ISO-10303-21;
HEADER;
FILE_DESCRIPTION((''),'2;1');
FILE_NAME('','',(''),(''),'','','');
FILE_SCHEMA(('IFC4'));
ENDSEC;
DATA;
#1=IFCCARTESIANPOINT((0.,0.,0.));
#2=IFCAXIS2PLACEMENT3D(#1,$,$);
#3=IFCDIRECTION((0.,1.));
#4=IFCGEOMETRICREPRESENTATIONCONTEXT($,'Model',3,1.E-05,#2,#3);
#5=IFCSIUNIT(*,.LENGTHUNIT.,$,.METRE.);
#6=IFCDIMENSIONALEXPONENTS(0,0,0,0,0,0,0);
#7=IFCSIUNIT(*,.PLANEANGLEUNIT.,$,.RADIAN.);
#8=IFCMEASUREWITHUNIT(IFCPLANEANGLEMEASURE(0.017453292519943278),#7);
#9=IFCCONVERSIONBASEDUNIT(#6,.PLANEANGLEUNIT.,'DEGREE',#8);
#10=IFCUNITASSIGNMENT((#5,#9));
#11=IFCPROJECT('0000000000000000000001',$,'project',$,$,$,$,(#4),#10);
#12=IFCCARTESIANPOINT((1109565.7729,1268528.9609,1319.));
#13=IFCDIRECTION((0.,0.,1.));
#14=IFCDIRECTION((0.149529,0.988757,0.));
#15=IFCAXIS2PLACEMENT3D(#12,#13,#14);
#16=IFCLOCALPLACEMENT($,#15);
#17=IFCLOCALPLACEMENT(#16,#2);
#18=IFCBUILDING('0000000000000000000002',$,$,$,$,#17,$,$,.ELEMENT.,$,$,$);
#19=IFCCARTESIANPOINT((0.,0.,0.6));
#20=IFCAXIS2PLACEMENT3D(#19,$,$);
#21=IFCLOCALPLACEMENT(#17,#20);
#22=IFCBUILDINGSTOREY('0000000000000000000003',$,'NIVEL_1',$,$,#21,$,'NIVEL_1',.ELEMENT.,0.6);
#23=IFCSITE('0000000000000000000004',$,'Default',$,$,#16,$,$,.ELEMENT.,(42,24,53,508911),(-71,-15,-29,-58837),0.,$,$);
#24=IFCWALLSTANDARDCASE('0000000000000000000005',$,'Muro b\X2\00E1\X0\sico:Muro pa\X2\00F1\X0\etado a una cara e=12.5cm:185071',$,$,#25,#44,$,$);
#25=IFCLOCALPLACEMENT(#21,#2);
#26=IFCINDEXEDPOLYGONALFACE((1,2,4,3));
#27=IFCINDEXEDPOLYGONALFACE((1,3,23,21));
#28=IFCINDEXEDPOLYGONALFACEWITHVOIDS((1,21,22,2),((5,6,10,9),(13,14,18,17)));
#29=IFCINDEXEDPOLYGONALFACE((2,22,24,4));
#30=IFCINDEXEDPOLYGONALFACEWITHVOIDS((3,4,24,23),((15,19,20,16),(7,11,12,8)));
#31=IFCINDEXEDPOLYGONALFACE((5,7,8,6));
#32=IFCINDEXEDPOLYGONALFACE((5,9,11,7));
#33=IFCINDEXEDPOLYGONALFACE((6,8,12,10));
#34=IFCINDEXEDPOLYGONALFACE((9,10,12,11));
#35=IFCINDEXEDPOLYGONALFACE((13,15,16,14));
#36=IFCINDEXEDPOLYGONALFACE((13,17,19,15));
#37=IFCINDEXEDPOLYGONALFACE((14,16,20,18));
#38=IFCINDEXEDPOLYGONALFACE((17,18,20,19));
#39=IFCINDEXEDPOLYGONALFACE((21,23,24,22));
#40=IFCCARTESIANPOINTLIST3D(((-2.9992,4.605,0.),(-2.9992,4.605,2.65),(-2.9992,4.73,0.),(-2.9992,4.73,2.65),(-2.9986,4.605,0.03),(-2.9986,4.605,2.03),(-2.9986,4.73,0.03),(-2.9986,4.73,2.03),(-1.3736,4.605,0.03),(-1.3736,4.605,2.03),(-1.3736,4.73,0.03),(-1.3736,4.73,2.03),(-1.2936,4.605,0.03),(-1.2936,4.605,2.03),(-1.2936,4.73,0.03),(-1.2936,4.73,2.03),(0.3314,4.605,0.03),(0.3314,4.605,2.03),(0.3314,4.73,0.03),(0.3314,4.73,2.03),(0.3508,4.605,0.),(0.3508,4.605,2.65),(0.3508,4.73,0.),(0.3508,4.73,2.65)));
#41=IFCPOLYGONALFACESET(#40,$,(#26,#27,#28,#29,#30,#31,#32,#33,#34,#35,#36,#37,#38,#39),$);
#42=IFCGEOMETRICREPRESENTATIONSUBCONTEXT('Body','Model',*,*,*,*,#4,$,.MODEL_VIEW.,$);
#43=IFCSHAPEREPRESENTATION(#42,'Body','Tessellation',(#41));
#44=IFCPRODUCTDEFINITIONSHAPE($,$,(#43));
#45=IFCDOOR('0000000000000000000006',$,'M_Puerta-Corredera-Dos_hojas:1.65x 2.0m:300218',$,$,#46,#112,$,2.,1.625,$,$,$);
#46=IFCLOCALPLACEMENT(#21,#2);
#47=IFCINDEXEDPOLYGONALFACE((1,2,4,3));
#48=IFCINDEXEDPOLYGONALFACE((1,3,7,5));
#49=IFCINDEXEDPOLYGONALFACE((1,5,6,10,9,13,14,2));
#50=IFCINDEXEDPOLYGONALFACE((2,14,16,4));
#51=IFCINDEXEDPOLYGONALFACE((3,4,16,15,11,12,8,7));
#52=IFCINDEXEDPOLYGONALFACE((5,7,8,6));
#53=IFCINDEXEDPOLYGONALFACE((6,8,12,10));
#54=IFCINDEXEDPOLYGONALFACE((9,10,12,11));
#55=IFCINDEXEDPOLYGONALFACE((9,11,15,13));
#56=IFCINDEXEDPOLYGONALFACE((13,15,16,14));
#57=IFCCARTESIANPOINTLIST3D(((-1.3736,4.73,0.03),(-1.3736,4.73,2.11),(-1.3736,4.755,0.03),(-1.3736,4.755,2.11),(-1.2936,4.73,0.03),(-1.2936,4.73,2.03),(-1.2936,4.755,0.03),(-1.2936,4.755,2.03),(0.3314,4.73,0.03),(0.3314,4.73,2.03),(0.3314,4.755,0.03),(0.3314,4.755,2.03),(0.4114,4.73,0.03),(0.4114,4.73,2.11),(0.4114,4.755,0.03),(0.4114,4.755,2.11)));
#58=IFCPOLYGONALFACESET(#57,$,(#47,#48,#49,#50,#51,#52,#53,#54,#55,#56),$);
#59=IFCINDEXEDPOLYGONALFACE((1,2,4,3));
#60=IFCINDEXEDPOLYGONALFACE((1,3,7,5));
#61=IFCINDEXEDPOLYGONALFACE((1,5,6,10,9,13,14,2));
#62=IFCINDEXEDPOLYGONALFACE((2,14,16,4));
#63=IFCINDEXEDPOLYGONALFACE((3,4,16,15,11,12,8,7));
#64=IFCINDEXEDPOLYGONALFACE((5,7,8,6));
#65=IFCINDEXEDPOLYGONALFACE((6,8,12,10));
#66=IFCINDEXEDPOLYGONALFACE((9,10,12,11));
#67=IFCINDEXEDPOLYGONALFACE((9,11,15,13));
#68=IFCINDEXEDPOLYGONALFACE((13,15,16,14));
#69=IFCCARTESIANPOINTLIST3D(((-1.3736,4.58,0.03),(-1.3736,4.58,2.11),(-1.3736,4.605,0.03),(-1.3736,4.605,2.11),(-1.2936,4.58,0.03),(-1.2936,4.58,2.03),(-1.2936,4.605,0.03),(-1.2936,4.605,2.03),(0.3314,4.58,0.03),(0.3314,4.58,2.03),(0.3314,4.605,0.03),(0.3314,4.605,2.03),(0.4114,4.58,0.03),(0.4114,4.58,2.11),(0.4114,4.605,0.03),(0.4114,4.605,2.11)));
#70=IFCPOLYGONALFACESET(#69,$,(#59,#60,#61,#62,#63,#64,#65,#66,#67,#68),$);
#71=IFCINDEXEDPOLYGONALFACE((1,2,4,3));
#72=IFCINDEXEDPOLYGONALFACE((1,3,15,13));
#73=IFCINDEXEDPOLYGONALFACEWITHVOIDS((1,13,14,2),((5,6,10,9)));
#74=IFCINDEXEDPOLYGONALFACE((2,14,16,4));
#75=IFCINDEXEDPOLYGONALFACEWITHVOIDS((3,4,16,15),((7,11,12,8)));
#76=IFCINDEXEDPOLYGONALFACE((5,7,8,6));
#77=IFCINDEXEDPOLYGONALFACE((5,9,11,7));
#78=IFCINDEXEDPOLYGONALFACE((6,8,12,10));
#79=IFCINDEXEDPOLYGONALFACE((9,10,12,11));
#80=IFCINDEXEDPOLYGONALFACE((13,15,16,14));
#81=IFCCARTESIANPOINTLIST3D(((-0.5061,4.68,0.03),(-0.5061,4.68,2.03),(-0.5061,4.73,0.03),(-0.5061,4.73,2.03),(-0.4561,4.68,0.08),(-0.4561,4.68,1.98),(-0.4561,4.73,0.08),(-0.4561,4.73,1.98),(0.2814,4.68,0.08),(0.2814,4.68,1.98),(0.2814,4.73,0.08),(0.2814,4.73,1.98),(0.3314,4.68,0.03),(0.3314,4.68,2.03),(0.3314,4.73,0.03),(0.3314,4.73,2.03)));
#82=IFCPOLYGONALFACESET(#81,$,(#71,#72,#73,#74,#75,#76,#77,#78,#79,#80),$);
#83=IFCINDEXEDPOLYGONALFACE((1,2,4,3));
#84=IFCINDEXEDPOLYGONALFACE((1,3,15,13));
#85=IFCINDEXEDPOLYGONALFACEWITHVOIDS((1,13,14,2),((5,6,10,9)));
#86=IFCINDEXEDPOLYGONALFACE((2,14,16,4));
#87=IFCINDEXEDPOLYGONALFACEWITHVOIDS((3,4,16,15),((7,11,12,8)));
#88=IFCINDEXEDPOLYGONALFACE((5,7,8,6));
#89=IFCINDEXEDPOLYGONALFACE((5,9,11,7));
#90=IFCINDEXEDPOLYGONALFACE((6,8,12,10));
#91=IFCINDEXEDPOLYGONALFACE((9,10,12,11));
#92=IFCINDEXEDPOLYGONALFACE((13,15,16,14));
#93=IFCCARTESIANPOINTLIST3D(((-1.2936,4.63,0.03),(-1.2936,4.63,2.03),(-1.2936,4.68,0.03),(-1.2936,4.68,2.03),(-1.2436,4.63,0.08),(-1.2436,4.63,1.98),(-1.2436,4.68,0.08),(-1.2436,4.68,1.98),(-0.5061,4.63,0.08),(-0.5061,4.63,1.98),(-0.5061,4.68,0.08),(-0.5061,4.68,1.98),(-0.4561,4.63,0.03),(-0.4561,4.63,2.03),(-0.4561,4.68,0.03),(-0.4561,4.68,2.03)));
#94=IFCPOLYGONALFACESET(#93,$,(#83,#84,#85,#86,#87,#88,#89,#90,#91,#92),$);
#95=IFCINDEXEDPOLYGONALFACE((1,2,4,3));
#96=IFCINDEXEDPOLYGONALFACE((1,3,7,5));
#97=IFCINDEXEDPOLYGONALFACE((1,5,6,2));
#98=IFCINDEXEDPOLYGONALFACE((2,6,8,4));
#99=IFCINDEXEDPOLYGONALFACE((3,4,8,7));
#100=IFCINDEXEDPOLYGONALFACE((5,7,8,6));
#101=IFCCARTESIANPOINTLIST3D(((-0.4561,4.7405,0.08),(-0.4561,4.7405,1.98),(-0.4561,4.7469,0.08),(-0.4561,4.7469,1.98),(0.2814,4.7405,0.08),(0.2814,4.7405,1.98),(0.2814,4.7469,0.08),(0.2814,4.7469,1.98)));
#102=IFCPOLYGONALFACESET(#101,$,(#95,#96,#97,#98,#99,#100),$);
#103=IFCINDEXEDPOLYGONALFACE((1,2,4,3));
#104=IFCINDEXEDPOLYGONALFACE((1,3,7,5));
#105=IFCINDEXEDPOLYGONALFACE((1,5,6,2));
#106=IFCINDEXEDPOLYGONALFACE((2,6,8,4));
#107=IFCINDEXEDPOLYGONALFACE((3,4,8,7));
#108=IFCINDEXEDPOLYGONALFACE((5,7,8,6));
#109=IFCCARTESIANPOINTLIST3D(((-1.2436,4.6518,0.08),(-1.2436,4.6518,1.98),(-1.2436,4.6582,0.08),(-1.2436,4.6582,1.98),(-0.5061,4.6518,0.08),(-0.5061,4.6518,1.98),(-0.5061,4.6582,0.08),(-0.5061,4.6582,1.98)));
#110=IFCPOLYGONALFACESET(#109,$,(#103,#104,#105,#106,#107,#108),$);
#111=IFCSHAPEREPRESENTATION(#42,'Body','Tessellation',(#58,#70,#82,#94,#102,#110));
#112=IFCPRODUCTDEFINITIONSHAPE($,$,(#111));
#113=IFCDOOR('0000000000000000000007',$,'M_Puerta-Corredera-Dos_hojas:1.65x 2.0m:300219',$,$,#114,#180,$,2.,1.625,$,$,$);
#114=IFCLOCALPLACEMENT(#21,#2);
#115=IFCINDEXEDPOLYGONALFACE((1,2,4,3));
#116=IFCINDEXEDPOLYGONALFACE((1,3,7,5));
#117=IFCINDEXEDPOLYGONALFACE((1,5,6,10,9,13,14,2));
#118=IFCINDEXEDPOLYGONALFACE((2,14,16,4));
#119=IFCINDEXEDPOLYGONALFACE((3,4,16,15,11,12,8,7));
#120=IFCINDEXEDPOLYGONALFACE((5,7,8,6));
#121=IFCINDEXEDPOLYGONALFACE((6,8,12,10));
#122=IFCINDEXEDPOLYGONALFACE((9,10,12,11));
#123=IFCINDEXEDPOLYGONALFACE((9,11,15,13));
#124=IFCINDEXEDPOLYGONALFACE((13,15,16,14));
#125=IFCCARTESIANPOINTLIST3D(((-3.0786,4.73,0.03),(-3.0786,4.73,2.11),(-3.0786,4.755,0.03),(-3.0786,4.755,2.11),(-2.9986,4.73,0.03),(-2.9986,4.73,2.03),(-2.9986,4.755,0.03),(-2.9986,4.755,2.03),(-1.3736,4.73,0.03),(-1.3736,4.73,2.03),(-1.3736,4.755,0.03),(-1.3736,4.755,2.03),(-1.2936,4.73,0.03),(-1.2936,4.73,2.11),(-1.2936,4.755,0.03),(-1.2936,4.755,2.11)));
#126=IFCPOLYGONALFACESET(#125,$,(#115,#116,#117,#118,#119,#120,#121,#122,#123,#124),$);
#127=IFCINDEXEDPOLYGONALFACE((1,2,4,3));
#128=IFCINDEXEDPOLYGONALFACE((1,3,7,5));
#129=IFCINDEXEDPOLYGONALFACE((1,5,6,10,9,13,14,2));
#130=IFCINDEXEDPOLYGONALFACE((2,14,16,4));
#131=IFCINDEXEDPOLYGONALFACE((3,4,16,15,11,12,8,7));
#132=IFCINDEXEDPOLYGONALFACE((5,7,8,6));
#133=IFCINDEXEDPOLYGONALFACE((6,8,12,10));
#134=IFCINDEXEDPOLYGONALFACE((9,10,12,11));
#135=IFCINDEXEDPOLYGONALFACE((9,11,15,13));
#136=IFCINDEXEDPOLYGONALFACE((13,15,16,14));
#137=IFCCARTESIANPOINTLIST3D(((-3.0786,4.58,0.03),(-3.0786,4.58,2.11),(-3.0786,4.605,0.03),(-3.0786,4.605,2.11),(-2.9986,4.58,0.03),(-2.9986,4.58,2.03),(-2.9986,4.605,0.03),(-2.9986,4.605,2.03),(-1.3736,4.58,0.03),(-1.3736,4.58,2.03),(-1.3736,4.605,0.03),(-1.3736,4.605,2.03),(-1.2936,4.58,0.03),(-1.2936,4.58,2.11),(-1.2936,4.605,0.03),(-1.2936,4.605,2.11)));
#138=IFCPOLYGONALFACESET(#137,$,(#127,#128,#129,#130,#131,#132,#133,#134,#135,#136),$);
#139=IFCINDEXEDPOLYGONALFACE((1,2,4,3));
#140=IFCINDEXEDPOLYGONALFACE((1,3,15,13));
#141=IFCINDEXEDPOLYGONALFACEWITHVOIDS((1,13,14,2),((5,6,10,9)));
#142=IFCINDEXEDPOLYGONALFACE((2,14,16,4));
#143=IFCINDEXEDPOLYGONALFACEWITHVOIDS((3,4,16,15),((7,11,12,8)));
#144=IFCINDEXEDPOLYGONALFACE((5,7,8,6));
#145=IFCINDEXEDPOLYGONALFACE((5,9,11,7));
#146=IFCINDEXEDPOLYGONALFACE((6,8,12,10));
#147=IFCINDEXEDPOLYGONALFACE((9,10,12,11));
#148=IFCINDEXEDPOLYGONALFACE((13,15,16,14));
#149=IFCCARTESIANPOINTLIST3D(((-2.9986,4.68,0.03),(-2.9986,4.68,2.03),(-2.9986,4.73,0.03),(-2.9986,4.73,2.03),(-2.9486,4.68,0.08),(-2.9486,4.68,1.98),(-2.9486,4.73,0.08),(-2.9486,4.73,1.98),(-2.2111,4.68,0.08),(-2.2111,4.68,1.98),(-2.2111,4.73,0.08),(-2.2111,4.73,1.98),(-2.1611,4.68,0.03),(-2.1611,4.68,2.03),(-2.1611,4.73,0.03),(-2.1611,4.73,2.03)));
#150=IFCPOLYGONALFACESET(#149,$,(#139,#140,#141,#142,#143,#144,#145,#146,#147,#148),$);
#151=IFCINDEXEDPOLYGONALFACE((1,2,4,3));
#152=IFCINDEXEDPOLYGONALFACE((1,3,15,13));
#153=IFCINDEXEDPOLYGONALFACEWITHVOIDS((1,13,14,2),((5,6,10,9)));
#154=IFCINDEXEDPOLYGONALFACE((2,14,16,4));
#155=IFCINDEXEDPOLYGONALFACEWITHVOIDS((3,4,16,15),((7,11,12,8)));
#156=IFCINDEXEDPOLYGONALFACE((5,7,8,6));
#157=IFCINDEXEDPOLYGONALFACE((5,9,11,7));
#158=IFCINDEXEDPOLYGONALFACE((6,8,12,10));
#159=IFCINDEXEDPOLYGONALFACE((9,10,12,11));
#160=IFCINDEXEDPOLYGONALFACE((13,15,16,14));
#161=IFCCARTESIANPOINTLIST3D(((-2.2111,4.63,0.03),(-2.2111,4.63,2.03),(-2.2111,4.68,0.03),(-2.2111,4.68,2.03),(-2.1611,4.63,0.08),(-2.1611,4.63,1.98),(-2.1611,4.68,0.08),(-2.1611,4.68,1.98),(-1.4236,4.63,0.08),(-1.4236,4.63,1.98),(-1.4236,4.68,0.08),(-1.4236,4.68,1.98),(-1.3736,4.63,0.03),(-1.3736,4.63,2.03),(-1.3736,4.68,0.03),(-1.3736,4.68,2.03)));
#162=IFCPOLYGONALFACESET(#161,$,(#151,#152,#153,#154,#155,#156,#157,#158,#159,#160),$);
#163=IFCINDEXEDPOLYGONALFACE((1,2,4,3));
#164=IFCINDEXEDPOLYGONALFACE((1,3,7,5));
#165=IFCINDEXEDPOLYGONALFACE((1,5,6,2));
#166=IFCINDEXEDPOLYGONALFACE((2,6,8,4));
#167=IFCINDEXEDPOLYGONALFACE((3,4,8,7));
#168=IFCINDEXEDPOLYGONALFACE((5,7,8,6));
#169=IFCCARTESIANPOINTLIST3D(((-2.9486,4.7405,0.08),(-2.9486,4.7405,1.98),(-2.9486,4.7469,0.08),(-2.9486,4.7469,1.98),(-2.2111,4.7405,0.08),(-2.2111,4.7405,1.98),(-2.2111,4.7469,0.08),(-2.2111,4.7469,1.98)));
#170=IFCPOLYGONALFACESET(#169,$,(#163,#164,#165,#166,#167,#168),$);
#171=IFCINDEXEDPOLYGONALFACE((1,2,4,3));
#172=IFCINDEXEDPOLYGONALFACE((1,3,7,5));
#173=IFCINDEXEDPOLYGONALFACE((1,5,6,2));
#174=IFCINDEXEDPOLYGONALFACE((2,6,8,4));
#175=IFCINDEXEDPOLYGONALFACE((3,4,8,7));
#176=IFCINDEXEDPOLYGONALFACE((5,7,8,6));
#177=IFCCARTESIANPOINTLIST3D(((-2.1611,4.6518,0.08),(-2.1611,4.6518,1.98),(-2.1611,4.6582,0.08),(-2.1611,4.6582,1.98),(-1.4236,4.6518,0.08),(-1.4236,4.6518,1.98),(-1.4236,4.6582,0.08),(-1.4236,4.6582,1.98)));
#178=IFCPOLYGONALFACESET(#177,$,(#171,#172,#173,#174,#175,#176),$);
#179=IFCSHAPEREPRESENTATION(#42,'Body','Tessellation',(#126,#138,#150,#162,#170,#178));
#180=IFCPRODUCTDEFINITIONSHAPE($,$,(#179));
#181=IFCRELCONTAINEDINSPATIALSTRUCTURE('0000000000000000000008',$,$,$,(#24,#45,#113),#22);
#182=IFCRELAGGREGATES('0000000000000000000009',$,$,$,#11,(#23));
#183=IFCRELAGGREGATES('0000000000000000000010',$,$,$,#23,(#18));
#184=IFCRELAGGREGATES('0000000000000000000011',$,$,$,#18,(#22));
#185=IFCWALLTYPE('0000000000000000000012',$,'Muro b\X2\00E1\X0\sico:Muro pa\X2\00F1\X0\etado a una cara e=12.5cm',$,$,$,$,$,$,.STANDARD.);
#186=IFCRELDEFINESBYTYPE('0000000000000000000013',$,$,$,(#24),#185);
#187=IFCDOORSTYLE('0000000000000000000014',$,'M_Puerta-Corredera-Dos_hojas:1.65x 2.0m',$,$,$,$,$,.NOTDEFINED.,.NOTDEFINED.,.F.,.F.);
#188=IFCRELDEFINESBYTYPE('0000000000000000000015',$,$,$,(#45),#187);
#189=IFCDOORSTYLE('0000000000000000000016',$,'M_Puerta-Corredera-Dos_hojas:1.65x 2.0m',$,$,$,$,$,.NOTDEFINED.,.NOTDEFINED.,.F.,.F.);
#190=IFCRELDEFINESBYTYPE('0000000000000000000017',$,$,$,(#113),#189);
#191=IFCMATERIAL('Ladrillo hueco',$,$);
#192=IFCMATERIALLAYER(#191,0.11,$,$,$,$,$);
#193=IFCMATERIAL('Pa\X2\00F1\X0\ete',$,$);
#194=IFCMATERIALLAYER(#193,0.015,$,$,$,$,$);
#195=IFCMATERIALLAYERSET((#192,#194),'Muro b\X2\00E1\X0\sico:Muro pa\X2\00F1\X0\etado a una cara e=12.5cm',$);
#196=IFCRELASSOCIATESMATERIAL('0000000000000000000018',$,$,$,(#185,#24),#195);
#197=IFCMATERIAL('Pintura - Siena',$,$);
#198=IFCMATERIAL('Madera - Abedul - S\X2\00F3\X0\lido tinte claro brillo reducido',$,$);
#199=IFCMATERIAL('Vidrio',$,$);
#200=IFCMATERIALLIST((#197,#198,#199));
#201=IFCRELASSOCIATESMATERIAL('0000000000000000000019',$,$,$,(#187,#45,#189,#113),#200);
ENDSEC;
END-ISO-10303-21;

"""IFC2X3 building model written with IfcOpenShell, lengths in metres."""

from ifc_helpers import new_model, entity, si_unit, converted_unit, direction, frame, frame_2d, origin, origin_2d_with_axis, place, context, subcontext, project, spatial, polyline, rectangle, outline, extrude, source, transform, mapped, material, material_list, layer, layer_set, layer_usage, type_object, type_shapes, element, fill, save


model = new_model("IFC2X3")

# Units and contexts
model_context = context("Model", 3, precision=1e-05, world=origin(), true_north=direction((0.0, 1.0)))
body_context = subcontext(model_context, "Body", "Model", "MODEL_VIEW")
ifc_project = project(units=[si_unit("LENGTHUNIT", "METRE"), converted_unit("PLANEANGLEUNIT", "DEGREE", entity("IfcPlaneAngleMeasure", 0.017453292519943278), si_unit("PLANEANGLEUNIT", "RADIAN"), dimensions=[0, 0, 0, 0, 0, 0, 0])], contexts=[model_context])

# Site, building, storey
site_placement = place(None, frame((1109565.7729, 1268528.9609, 1319.0), z_axis=(0.0, 0.0, 1.0), x_axis=(0.149529, 0.988757, 0.0)))
site = spatial("IfcSite", under=ifc_project, at=site_placement, Name="Default", CompositionType="ELEMENT", RefLatitude=(42, 24, 53, 508911), RefLongitude=(-71, -15, -29, -58837), RefElevation=0.0)
building_placement = place(site_placement, origin())
building = spatial("IfcBuilding", under=site, at=building_placement, CompositionType="ELEMENT")
storey_placement = place(building_placement, frame((0.0, 0.0, 0.6)))
storey = spatial("IfcBuildingStorey", under=building, at=storey_placement, Name="NIVEL_1", LongName="NIVEL_1", CompositionType="ELEMENT", Elevation=0.6)

# Shared definitions
ifc_material_1 = material(Name="Pañete")
ifc_material_2 = material(Name="Ladrillo hueco")

# Wall, openings, doors
ifc_layer_1 = layer(ifc_material_2, 0.11)
ifc_layer_2 = layer(ifc_material_1, 0.015)
ifc_layer_set_1 = layer_set([ifc_layer_1, ifc_layer_2], Name="Muro básico:Muro pañetado a una cara e=12.5cm")
ifc_layer_usage_1 = layer_usage(ifc_layer_set_1, "AXIS2", "NEGATIVE", 0.0625)
wall_type_1 = type_object("IfcWallType", Name="Muro básico:Muro pañetado a una cara e=12.5cm", PredefinedType="STANDARD", material=ifc_layer_set_1)
wall_1_placement = place(storey_placement, frame((-2.9992, 4.6675, 0.0)))
wall_1 = element("IfcWallStandardCase", 1, at=wall_1_placement, inside=storey, type_object=wall_type_1, material=ifc_layer_usage_1, Name="Muro básico:Muro pañetado a una cara e=12.5cm:185071", context=body_context, shape_type="SweptSolid", body=[
    extrude(rectangle(XDim=3.35, YDim=0.125, at=frame_2d((1.675, 0.0), x_axis=(-1.0, 0.0))), origin(), (0.0, 0.0, 1.0), 2.65),
])
opening_1_placement = place(wall_1_placement, frame((0.0006, -0.0625, 0.03)))
opening_1 = element("IfcOpeningElement", 2, at=opening_1_placement, cuts=wall_1, ObjectType="Opening", context=body_context, shape_type="SweptSolid", body=[
    extrude(rectangle(XDim=2.0, YDim=1.625, at=frame_2d((1.0, 0.8125), x_axis=(-1.0, 0.0))), frame((0.0, 0.0, 0.0), z_axis=(0.0, 1.0, 0.0), x_axis=(0.0, 0.0, 1.0)), (0.0, 0.0, 1.0), 0.125),
])
opening_2_placement = place(wall_1_placement, frame((1.7056, -0.0625, 0.03)))
opening_2 = element("IfcOpeningElement", 3, at=opening_2_placement, cuts=wall_1, ObjectType="Opening", context=body_context, shape_type="SweptSolid", body=[
    extrude(rectangle(XDim=2.0, YDim=1.625, at=frame_2d((1.0, 0.8125), x_axis=(-1.0, 0.0))), frame((0.0, 0.0, 0.0), z_axis=(0.0, 1.0, 0.0), x_axis=(0.0, 0.0, 1.0)), (0.0, 0.0, 1.0), 0.125),
])
ifc_material_3 = material(Name="Pintura - Siena")
ifc_material_4 = material(Name="Madera - Abedul - Sólido tinte claro brillo reducido")
ifc_material_5 = material(Name="Vidrio")
ifc_material_list = material_list([ifc_material_3, ifc_material_4, ifc_material_5])
door_style_1 = type_object("IfcDoorStyle", Name="M_Puerta-Corredera-Dos_hojas:1.65x 2.0m", ConstructionType="NOTDEFINED", OperationType="NOTDEFINED", ParameterTakesPrecedence=False, Sizeable=False, material=ifc_material_list)
shared_shape_1 = source(origin(), body_context, "Body", "SweptSolid", [
    extrude(outline(polyline([(-0.8925, -1.02), (-0.8125, -1.02), (-0.8125, 0.98), (0.8125, 0.98), (0.8125, -1.02), (0.8925, -1.02), (0.8925, 1.06), (-0.8925, 1.06), (-0.8925, -1.02)])), frame((0.8125, 0.404, 1.02), z_axis=(0.0, -1.0, 0.0), x_axis=(1.0, 0.0, 0.0)), (0.0, 0.0, 1.0), 0.025),
    extrude(outline(polyline([(-1.02, -0.8925), (1.06, -0.8925), (1.06, 0.8925), (-1.02, 0.8925), (-1.02, 0.8125), (0.98, 0.8125), (0.98, -0.8125), (-1.02, -0.8125), (-1.02, -0.8925)])), frame((0.8125, 0.254, 1.02), z_axis=(0.0, -1.0, 0.0), x_axis=(0.0, 0.0, 1.0)), (0.0, 0.0, 1.0), 0.025),
    extrude(outline(polyline([(-1.0, -0.4187), (1.0, -0.4187), (1.0, 0.4187), (-1.0, 0.4187), (-1.0, -0.4187)]), holes=[polyline([(-0.95, -0.3688), (-0.95, 0.3687), (0.95, 0.3687), (0.95, -0.3688), (-0.95, -0.3688)])]), frame((1.2063, 0.379, 1.0), z_axis=(0.0, -1.0, 0.0), x_axis=(0.0, 0.0, -1.0)), (0.0, 0.0, 1.0), 0.05),
    extrude(outline(polyline([(-0.4187, -1.0), (0.4187, -1.0), (0.4187, 1.0), (-0.4187, 1.0), (-0.4187, -1.0)]), holes=[polyline([(-0.3688, -0.95), (-0.3688, 0.95), (0.3688, 0.95), (0.3688, -0.95), (-0.3688, -0.95)])]), frame((0.4187, 0.329, 1.0), z_axis=(0.0, -1.0, 0.0), x_axis=(-1.0, 0.0, 0.0)), (0.0, 0.0, 1.0), 0.05),
    extrude(rectangle(XDim=0.7375, YDim=0.0064, at=origin_2d_with_axis()), frame((1.2062, 0.3927, 0.05)), (0.0, 0.0, 1.0), 1.9),
    extrude(rectangle(XDim=0.7375, YDim=0.0063, at=frame_2d((0.0, 0.0), x_axis=(1.0, 0.0))), frame((0.4187, 0.304, 0.05), z_axis=(0.0, 0.0, 1.0), x_axis=(-1.0, 0.0, 0.0)), (0.0, 0.0, 1.0), 1.9),
])
type_shapes(door_style_1, [shared_shape_1])
door_1_placement = place(opening_2_placement, frame((0.0, -0.254, 0.0)))
door_1 = element("IfcDoor", 4, at=door_1_placement, inside=storey, type_object=door_style_1, material=ifc_material_list, Name="M_Puerta-Corredera-Dos_hojas:1.65x 2.0m:300218", OverallHeight=2.0, OverallWidth=1.625, context=body_context, shape_type="MappedRepresentation", body=[
    mapped(shared_shape_1, transform((0.0, 0.0, 0.0), scale=1.0)),
])
fill(opening_2, door_1)
door_style_2 = type_object("IfcDoorStyle", Name="M_Puerta-Corredera-Dos_hojas:1.65x 2.0m", ConstructionType="NOTDEFINED", OperationType="NOTDEFINED", ParameterTakesPrecedence=False, Sizeable=False, material=ifc_material_list)
shared_shape_2 = source(origin(), body_context, "Body", "SweptSolid", [
    extrude(outline(polyline([(-0.8925, -1.02), (-0.8125, -1.02), (-0.8125, 0.98), (0.8125, 0.98), (0.8125, -1.02), (0.8925, -1.02), (0.8925, 1.06), (-0.8925, 1.06), (-0.8925, -1.02)])), frame((0.8125, 0.125, 1.02), z_axis=(0.0, 1.0, 0.0), x_axis=(-1.0, 0.0, 0.0)), (0.0, 0.0, 1.0), 0.025),
    extrude(outline(polyline([(-1.02, -0.8925), (1.06, -0.8925), (1.06, 0.8925), (-1.02, 0.8925), (-1.02, 0.8125), (0.98, 0.8125), (0.98, -0.8125), (-1.02, -0.8125), (-1.02, -0.8925)])), frame((0.8125, -0.025, 1.02), z_axis=(0.0, 1.0, 0.0), x_axis=(0.0, 0.0, 1.0)), (0.0, 0.0, 1.0), 0.025),
    extrude(outline(polyline([(-1.0, -0.4187), (1.0, -0.4187), (1.0, 0.4187), (-1.0, 0.4187), (-1.0, -0.4187)]), holes=[polyline([(-0.95, -0.3688), (-0.95, 0.3687), (0.95, 0.3687), (0.95, -0.3688), (-0.95, -0.3688)])]), frame((0.4188, 0.075, 1.0), z_axis=(0.0, 1.0, 0.0), x_axis=(0.0, 0.0, -1.0)), (0.0, 0.0, 1.0), 0.05),
    extrude(outline(polyline([(-0.4187, -1.0), (0.4187, -1.0), (0.4187, 1.0), (-0.4187, 1.0), (-0.4187, -1.0)]), holes=[polyline([(-0.3688, -0.95), (-0.3688, 0.95), (0.3688, 0.95), (0.3688, -0.95), (-0.3688, -0.95)])]), frame((1.2063, 0.025, 1.0), z_axis=(0.0, 1.0, 0.0), x_axis=(1.0, 0.0, 0.0)), (0.0, 0.0, 1.0), 0.05),
    extrude(rectangle(XDim=0.0064, YDim=0.7375, at=origin_2d_with_axis()), frame((0.4188, 0.1387, 0.05), z_axis=(0.0, 0.0, 1.0), x_axis=(0.0, 1.0, 0.0)), (0.0, 0.0, 1.0), 1.9),
    extrude(rectangle(XDim=0.0063, YDim=0.7375, at=frame_2d((0.0, 0.0), x_axis=(1.0, 0.0))), frame((1.2063, 0.05, 0.05), z_axis=(0.0, 0.0, 1.0), x_axis=(0.0, -1.0, 0.0)), (0.0, 0.0, 1.0), 1.9),
])
type_shapes(door_style_2, [shared_shape_2])
door_2_placement = place(opening_1_placement, origin())
door_2 = element("IfcDoor", 5, at=door_2_placement, inside=storey, type_object=door_style_2, material=ifc_material_list, Name="M_Puerta-Corredera-Dos_hojas:1.65x 2.0m:300219", OverallHeight=2.0, OverallWidth=1.625, context=body_context, shape_type="MappedRepresentation", body=[
    mapped(shared_shape_2, transform((0.0, 0.0, 0.0), scale=1.0)),
])
fill(opening_1, door_2)

save(model, "model.ifc")
